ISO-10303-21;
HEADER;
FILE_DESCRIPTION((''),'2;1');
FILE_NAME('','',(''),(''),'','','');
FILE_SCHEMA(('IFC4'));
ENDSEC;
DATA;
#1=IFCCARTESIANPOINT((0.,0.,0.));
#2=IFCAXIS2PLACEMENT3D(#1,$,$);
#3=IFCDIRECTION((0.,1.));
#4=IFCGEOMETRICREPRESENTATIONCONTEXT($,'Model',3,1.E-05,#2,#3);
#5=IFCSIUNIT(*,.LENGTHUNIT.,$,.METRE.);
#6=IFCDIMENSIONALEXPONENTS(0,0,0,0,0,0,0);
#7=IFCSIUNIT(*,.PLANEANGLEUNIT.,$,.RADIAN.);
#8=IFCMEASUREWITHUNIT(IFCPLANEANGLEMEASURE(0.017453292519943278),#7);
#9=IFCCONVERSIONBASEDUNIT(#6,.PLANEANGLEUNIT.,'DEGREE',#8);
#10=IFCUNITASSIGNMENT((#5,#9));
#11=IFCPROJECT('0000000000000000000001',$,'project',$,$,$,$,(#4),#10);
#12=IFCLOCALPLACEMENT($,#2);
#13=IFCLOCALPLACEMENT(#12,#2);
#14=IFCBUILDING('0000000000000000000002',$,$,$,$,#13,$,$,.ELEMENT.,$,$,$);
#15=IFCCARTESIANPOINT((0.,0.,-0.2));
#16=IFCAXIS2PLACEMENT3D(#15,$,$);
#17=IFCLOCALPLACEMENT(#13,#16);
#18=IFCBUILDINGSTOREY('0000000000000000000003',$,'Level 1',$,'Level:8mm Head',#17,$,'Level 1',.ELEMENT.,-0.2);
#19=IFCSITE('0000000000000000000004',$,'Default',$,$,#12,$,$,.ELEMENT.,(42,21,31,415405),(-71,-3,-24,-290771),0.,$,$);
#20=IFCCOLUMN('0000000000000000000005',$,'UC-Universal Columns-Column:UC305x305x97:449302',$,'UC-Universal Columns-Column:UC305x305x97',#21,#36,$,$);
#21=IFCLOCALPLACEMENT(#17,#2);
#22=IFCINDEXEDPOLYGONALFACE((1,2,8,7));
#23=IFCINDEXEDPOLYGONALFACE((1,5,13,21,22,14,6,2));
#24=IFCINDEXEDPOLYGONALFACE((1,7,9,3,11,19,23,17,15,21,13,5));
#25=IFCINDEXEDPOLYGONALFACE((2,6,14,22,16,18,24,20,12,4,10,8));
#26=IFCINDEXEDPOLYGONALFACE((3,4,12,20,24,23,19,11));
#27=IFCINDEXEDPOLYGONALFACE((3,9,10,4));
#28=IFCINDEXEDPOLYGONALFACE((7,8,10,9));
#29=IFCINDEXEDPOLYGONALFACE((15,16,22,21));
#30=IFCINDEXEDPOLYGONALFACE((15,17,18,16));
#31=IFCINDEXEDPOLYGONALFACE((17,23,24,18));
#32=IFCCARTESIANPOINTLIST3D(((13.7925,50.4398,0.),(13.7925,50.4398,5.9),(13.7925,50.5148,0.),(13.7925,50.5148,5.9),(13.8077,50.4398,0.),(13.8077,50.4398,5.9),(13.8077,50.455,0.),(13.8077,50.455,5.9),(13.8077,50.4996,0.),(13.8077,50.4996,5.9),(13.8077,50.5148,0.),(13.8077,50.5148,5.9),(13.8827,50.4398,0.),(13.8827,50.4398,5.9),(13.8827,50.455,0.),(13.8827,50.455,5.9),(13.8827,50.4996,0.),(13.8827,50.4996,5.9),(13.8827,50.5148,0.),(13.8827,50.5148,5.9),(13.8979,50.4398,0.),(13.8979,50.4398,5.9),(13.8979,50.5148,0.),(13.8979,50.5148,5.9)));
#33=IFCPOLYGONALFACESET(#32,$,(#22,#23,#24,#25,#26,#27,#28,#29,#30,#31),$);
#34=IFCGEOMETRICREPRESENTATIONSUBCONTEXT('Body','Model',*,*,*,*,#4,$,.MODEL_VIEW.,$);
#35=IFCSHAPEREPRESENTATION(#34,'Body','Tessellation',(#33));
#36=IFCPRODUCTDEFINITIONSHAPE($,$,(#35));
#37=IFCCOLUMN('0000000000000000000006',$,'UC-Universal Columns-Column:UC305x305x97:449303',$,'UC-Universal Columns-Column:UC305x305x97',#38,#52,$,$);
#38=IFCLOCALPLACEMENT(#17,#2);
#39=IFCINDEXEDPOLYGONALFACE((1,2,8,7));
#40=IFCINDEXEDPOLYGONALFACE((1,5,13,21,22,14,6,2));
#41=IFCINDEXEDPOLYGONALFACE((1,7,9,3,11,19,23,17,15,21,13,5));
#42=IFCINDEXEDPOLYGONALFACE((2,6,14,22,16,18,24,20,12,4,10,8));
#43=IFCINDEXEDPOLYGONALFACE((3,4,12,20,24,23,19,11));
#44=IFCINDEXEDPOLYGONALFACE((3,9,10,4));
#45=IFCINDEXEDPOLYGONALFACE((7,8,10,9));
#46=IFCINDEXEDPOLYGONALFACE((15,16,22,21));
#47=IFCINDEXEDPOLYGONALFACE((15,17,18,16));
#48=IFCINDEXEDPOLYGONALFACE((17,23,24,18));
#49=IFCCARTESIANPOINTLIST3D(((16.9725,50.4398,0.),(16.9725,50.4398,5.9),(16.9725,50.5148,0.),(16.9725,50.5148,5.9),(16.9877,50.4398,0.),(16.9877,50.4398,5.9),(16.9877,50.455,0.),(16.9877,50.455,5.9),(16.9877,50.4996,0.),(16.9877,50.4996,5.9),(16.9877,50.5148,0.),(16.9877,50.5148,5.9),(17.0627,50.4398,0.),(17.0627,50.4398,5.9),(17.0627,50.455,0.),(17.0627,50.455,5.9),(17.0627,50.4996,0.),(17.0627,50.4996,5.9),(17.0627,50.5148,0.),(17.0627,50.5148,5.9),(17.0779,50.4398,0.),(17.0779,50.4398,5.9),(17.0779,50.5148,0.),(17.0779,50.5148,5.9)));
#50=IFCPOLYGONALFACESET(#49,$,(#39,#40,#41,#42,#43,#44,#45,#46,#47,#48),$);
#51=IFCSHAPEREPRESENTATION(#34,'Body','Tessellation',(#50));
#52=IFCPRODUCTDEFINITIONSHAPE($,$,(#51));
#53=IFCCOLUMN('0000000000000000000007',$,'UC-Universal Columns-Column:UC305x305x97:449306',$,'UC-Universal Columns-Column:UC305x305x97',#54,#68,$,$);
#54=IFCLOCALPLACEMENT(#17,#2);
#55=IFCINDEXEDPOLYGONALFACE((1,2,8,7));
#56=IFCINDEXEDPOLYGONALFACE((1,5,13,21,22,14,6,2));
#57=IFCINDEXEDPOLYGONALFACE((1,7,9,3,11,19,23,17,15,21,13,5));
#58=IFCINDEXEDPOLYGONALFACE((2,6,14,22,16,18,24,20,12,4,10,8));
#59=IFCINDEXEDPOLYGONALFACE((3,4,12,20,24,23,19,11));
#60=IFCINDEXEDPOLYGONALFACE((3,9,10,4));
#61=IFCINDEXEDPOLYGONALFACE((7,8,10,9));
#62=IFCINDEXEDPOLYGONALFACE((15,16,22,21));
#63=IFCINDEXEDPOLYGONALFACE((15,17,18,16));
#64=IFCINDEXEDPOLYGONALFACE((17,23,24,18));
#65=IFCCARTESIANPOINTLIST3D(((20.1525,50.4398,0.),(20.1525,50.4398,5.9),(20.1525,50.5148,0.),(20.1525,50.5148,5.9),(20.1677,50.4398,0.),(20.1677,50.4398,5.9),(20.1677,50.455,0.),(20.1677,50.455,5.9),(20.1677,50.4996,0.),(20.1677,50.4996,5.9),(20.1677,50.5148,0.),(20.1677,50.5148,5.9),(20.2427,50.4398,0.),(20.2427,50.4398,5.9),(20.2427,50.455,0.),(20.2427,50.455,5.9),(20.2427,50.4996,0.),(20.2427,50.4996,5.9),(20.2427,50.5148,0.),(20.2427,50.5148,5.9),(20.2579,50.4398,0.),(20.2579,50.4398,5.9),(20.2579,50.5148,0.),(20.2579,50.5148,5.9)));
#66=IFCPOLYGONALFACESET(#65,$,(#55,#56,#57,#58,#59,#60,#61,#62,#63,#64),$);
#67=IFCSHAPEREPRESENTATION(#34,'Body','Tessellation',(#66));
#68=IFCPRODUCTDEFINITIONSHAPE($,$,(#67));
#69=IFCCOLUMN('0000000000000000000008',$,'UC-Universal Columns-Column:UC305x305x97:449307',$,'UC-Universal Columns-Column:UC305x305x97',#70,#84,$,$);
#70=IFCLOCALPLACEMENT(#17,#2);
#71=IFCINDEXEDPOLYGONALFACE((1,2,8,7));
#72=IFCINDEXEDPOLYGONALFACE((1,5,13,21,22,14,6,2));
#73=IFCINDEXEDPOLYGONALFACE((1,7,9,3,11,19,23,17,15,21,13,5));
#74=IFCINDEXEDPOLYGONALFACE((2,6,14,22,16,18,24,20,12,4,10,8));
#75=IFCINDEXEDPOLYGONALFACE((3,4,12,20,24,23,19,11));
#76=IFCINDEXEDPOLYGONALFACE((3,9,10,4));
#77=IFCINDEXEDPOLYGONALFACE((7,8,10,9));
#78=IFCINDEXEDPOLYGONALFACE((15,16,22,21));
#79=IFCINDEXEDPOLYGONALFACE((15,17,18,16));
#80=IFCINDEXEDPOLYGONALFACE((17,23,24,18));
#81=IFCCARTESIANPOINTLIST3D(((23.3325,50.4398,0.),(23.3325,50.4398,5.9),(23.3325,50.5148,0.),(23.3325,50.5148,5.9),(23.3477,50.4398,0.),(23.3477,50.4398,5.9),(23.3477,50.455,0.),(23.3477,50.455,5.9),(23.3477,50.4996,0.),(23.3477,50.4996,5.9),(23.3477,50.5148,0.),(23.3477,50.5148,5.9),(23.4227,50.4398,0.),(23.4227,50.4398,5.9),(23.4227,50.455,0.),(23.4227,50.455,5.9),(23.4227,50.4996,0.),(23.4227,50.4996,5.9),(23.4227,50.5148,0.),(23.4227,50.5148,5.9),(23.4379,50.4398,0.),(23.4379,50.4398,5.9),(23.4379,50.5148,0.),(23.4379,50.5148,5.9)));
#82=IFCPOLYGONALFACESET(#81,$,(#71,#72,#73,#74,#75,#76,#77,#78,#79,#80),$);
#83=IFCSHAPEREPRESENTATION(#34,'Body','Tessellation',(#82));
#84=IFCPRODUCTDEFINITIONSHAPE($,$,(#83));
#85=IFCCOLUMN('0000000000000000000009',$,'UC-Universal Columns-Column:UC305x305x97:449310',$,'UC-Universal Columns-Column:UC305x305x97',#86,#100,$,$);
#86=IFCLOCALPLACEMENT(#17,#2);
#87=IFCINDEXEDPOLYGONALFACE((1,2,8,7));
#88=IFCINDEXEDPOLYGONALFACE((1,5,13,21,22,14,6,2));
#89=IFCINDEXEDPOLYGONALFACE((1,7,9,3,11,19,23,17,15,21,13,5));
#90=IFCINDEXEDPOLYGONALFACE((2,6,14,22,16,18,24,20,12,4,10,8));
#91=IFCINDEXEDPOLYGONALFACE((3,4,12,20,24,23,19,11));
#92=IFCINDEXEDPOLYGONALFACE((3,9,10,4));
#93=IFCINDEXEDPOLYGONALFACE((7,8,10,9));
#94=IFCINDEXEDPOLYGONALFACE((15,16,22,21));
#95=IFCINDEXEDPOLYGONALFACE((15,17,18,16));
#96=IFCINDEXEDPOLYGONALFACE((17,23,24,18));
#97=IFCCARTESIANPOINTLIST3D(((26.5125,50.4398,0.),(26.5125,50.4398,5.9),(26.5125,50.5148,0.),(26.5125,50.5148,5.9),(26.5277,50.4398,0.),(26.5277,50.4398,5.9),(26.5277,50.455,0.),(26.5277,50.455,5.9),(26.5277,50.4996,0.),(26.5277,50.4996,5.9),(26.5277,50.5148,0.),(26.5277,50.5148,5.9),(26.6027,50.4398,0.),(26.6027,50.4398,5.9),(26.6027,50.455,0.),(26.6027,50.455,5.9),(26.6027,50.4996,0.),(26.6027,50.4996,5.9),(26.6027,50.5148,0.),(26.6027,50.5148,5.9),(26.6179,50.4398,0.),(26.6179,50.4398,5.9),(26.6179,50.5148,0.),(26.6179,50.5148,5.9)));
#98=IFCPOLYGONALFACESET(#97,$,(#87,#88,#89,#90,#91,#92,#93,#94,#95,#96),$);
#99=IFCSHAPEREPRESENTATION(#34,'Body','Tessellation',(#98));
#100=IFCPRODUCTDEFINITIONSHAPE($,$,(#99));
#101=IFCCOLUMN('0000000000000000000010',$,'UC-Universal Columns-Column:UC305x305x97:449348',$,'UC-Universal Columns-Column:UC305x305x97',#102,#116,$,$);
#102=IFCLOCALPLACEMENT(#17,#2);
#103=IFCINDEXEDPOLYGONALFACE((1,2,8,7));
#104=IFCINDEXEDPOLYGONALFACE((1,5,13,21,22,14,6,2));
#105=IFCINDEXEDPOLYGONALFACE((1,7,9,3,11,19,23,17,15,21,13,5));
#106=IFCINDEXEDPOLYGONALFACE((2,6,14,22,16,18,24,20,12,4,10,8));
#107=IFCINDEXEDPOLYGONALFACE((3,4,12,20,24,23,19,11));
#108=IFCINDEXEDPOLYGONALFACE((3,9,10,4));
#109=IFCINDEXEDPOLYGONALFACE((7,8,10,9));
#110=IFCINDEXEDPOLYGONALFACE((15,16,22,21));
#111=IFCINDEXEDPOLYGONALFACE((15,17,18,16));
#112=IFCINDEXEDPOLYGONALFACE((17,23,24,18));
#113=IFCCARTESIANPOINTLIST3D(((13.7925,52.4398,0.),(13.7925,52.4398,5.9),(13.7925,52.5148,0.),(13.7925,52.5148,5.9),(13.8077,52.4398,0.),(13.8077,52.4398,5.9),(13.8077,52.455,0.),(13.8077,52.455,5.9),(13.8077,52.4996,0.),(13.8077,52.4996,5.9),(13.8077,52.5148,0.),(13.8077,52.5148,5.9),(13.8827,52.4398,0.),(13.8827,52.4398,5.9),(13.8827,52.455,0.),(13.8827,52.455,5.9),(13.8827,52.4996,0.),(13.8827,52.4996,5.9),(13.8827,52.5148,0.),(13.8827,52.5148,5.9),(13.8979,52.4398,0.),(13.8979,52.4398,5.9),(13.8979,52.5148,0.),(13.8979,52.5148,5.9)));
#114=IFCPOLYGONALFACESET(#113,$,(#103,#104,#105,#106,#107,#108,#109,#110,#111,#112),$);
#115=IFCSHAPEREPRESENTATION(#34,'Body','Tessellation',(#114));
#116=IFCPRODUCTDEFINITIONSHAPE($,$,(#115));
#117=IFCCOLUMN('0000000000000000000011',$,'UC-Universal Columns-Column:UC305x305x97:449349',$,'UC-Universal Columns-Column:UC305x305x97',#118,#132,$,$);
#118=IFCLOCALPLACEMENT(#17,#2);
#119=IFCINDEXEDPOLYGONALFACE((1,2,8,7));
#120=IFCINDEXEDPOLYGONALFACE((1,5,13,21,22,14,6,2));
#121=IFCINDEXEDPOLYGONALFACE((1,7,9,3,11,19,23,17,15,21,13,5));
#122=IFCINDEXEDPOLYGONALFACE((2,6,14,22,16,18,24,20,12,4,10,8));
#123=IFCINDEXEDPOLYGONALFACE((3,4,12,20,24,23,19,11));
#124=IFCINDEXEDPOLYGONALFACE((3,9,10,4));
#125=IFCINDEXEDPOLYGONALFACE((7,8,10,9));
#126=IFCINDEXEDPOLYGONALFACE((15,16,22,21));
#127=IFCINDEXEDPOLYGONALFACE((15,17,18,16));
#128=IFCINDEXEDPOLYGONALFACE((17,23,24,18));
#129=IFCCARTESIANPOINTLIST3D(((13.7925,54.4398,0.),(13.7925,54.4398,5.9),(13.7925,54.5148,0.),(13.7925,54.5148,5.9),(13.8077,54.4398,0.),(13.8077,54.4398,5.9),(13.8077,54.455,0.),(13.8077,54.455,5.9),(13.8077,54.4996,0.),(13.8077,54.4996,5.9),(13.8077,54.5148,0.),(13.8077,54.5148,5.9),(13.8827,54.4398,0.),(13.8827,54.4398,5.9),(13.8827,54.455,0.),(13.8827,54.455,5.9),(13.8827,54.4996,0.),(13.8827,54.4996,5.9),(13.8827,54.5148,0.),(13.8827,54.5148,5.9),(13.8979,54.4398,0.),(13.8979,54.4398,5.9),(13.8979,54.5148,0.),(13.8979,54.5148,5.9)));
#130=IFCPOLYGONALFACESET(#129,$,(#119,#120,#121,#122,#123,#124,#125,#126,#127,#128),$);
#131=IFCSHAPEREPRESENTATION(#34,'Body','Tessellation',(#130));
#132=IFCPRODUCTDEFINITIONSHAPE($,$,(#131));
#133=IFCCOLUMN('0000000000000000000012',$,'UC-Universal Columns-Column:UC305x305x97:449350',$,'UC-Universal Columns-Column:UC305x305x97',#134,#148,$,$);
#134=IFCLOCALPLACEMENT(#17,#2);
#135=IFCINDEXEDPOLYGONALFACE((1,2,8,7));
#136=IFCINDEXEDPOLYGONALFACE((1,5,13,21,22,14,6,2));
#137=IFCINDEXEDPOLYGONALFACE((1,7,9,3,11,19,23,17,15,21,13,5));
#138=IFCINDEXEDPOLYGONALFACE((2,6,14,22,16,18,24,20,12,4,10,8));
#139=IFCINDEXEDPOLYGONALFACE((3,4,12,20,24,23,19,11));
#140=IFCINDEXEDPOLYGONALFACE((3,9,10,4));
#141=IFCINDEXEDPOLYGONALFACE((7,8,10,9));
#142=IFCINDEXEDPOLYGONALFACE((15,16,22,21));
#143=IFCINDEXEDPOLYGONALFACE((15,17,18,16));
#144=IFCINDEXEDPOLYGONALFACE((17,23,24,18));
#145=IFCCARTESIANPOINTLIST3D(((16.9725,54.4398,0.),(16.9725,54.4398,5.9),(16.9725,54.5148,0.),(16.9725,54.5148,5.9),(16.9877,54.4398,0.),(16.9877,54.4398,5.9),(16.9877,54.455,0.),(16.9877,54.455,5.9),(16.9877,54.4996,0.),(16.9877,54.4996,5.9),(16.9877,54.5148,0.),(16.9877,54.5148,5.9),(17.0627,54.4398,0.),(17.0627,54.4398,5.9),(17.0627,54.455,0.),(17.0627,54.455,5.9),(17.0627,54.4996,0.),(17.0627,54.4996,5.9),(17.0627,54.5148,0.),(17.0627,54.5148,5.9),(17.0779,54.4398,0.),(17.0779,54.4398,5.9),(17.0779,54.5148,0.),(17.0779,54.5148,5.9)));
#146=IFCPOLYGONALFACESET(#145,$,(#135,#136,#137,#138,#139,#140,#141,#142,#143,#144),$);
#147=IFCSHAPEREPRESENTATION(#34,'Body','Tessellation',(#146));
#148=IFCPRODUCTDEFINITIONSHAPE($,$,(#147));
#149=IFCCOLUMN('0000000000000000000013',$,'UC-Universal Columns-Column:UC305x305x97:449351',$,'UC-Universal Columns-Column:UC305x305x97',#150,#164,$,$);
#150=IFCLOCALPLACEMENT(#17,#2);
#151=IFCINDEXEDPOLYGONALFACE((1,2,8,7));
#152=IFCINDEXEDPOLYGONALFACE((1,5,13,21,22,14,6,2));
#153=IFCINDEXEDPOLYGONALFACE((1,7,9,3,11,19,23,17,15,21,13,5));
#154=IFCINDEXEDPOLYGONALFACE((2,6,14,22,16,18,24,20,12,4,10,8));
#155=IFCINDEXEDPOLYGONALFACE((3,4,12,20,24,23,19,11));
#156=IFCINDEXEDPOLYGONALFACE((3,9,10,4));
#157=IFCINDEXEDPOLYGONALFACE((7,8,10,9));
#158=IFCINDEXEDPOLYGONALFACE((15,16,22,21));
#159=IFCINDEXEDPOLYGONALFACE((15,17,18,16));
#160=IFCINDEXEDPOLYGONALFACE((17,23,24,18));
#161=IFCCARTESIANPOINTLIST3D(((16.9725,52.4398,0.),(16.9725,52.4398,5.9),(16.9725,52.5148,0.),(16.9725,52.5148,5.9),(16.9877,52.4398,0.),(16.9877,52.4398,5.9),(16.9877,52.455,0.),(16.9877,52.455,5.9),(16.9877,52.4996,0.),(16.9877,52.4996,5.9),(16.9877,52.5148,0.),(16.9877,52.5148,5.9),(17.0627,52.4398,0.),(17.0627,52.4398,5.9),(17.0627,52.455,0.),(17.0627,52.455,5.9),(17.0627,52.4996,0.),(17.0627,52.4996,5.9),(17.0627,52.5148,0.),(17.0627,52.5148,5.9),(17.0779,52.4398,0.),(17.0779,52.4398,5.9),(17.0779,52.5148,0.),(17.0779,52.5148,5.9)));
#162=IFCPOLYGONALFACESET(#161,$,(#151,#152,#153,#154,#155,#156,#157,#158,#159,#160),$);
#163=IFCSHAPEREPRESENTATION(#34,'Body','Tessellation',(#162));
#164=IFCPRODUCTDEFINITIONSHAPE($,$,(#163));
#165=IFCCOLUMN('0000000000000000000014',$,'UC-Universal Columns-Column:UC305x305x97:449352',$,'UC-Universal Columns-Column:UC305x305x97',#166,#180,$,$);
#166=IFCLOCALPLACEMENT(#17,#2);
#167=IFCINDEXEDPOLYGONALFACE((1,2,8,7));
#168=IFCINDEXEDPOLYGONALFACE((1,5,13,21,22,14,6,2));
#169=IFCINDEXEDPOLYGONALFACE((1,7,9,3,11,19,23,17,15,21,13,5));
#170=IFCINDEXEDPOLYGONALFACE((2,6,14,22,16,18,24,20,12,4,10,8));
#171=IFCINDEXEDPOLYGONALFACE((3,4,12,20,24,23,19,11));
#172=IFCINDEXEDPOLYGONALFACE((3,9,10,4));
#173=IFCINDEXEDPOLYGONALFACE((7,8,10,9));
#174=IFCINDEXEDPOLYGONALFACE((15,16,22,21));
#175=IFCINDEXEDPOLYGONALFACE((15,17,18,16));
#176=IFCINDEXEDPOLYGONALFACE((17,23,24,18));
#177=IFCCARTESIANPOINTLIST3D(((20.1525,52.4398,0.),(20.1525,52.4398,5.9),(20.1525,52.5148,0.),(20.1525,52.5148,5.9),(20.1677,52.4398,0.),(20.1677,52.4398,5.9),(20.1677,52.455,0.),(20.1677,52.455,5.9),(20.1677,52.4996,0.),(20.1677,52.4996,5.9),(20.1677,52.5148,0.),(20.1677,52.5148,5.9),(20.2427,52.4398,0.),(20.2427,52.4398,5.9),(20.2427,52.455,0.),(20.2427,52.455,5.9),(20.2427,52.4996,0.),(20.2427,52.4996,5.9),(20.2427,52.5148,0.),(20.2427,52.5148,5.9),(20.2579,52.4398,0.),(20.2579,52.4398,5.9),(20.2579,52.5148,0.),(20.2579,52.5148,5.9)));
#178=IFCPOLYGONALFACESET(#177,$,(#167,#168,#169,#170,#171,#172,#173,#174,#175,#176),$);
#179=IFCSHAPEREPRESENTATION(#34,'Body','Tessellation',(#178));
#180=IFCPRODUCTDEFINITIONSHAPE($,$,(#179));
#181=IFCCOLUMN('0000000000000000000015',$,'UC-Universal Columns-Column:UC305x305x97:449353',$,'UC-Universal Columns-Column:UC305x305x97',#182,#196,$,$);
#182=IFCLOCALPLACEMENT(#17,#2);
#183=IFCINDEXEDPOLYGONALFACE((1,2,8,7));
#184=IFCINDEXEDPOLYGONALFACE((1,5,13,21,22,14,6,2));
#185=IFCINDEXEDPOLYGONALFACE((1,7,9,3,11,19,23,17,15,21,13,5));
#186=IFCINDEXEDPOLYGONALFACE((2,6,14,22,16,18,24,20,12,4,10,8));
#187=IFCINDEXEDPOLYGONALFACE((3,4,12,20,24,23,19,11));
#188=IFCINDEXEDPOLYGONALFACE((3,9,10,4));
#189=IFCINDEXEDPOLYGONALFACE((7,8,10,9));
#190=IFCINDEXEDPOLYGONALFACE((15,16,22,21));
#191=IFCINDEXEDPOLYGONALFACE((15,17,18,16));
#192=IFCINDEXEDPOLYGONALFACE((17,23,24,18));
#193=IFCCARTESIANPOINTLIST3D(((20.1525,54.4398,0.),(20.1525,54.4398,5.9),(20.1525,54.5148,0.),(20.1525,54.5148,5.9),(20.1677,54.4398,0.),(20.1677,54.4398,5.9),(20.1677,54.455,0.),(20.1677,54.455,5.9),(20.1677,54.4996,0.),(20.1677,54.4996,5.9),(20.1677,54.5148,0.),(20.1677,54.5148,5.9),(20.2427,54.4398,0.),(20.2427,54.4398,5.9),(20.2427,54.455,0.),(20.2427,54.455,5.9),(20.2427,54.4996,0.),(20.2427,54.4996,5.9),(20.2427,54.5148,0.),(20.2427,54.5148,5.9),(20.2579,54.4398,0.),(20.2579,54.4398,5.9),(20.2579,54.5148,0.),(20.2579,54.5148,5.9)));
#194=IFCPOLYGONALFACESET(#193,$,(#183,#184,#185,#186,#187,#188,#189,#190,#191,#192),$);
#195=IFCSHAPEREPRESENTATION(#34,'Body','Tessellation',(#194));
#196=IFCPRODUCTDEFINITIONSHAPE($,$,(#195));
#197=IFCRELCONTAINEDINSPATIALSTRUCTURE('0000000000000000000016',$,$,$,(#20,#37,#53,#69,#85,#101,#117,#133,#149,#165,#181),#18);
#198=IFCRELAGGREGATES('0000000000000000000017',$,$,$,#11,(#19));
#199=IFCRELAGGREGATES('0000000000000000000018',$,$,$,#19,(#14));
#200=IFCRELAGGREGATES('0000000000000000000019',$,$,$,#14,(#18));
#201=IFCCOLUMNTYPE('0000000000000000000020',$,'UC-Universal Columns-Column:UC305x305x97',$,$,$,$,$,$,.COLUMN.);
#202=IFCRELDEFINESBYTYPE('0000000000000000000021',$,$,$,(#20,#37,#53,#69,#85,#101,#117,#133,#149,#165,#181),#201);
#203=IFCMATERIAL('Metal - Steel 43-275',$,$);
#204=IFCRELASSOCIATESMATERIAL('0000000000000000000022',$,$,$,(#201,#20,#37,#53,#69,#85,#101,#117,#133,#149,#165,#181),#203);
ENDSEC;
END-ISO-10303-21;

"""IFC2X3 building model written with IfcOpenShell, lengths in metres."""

from ifc_helpers import new_model, entity, si_unit, converted_unit, direction, frame, frame_2d, origin, place, context, subcontext, project, spatial, polyline, circle_curve, parameter, trimmed, segment, composite_curve, outline, extrude, source, transform, mapped, material, type_object, type_shapes, element, save


model = new_model("IFC2X3")

# Units and contexts
model_context = context("Model", 3, precision=1e-05, world=origin(), true_north=direction((0.0, 1.0)))
body_context = subcontext(model_context, "Body", "Model", "MODEL_VIEW")
ifc_project = project(units=[si_unit("LENGTHUNIT", "METRE"), converted_unit("PLANEANGLEUNIT", "DEGREE", entity("IfcPlaneAngleMeasure", 0.017453292519943278), si_unit("PLANEANGLEUNIT", "RADIAN"), dimensions=[0, 0, 0, 0, 0, 0, 0])], contexts=[model_context])

# Site, building, storey
site_placement = place(None, origin())
site = spatial("IfcSite", under=ifc_project, at=site_placement, Name="Default", CompositionType="ELEMENT", RefLatitude=(42, 21, 31, 415405), RefLongitude=(-71, -3, -24, -290771), RefElevation=0.0)
building_placement = place(site_placement, origin())
building = spatial("IfcBuilding", under=site, at=building_placement, CompositionType="ELEMENT")
storey_placement = place(building_placement, frame((0.0, 0.0, -0.2)))
storey = spatial("IfcBuildingStorey", under=building, at=storey_placement, Name="Level 1", ObjectType="Level:8mm Head", LongName="Level 1", CompositionType="ELEMENT", Elevation=-0.2)

# Columns
ifc_material = material(Name="Metal - Steel 43-275")
column_type = type_object("IfcColumnType", Name="UC-Universal Columns-Column:UC305x305x97", PredefinedType="COLUMN", material=ifc_material)
shared_shape = source(origin(), body_context, "Body", "SweptSolid", [
    extrude(outline(composite_curve([segment(polyline([(-0.0375, -0.0375), (0.0375, -0.0375)]), True, "CONTINUOUS"), segment(polyline([(0.0375, -0.0375), (0.0527, -0.0375)]), True, "CONTINUOUS"), segment(trimmed(circle_curve(frame_2d((0.0527, -0.0223), x_axis=(-1.0, 0.0)), 0.0152), [parameter(0.0)], [parameter(90.0)], True, "PARAMETER"), False, "CONTINUOUS"), segment(polyline([(0.0375, -0.0223), (0.0375, 0.0223)]), True, "CONTINUOUS"), segment(trimmed(circle_curve(frame_2d((0.0527, 0.0223), x_axis=(-1.0, 0.0)), 0.0152), [parameter(270.0)], [parameter(0.0)], True, "PARAMETER"), False, "CONTINUOUS"), segment(polyline([(0.0527, 0.0375), (0.0375, 0.0375)]), True, "CONTINUOUS"), segment(polyline([(0.0375, 0.0375), (-0.0375, 0.0375)]), True, "CONTINUOUS"), segment(polyline([(-0.0375, 0.0375), (-0.0527, 0.0375)]), True, "CONTINUOUS"), segment(trimmed(circle_curve(frame_2d((-0.0527, 0.0223), x_axis=(-1.0, 0.0)), 0.0152), [parameter(180.0)], [parameter(270.0)], True, "PARAMETER"), False, "CONTINUOUS"), segment(polyline([(-0.0375, 0.0223), (-0.0375, -0.0223)]), True, "CONTINUOUS"), segment(trimmed(circle_curve(frame_2d((-0.0527, -0.0223), x_axis=(-1.0, 0.0)), 0.0152), [parameter(90.0)], [parameter(180.0)], True, "PARAMETER"), False, "CONTINUOUS"), segment(polyline([(-0.0527, -0.0375), (-0.0375, -0.0375)]), True, "CONTINUOUS")], self_intersect=False)), frame((0.0, 0.0, -0.2), z_axis=(0.0, 0.0, 1.0), x_axis=(-1.0, 0.0, 0.0)), (0.0, 0.0, 1.0), 5.9),
])
type_shapes(column_type, [shared_shape])
for number, where, z_axis, x_axis, name in (
    (1, (13.8452, 50.4773, 0.2), (0.0, 0.0, 1.0), (-1.0, 0.0, 0.0), "UC-Universal Columns-Column:UC305x305x97:449302"),
    (2, (17.0252, 50.4773, 0.2), (0.0, 0.0, 1.0), (-1.0, 0.0, 0.0), "UC-Universal Columns-Column:UC305x305x97:449303"),
    (3, (20.2052, 50.4773, 0.2), (0.0, 0.0, 1.0), (-1.0, 0.0, 0.0), "UC-Universal Columns-Column:UC305x305x97:449306"),
    (4, (23.3852, 50.4773, 0.2), (0.0, 0.0, 1.0), (-1.0, 0.0, 0.0), "UC-Universal Columns-Column:UC305x305x97:449307"),
    (5, (26.5652, 50.4773, 0.2), (0.0, 0.0, 1.0), (-1.0, 0.0, 0.0), "UC-Universal Columns-Column:UC305x305x97:449310"),
    (6, (13.8452, 52.4773, 0.2), (0.0, 0.0, 1.0), (-1.0, 0.0, 0.0), "UC-Universal Columns-Column:UC305x305x97:449348"),
    (7, (13.8452, 54.4773, 0.2), (0.0, 0.0, 1.0), (-1.0, 0.0, 0.0), "UC-Universal Columns-Column:UC305x305x97:449349"),
    (8, (17.0252, 54.4773, 0.2), (0.0, 0.0, 1.0), (-1.0, 0.0, 0.0), "UC-Universal Columns-Column:UC305x305x97:449350"),
    (9, (17.0252, 52.4773, 0.2), (0.0, 0.0, 1.0), (-1.0, 0.0, 0.0), "UC-Universal Columns-Column:UC305x305x97:449351"),
    (10, (20.2052, 52.4773, 0.2), (0.0, 0.0, 1.0), (-1.0, 0.0, 0.0), "UC-Universal Columns-Column:UC305x305x97:449352"),
    (11, (20.2052, 54.4773, 0.2), (0.0, 0.0, 1.0), (-1.0, 0.0, 0.0), "UC-Universal Columns-Column:UC305x305x97:449353"),
):
    element("IfcColumn", number, at=place(storey_placement, frame(where, z_axis=z_axis, x_axis=x_axis)), inside=storey, type_object=column_type, material=ifc_material, Name=name, ObjectType="UC-Universal Columns-Column:UC305x305x97", context=body_context, shape_type="MappedRepresentation", body=[
        mapped(shared_shape, transform((0.0, 0.0, 0.0), scale=1.0)),
    ])

save(model, "model.ifc")
